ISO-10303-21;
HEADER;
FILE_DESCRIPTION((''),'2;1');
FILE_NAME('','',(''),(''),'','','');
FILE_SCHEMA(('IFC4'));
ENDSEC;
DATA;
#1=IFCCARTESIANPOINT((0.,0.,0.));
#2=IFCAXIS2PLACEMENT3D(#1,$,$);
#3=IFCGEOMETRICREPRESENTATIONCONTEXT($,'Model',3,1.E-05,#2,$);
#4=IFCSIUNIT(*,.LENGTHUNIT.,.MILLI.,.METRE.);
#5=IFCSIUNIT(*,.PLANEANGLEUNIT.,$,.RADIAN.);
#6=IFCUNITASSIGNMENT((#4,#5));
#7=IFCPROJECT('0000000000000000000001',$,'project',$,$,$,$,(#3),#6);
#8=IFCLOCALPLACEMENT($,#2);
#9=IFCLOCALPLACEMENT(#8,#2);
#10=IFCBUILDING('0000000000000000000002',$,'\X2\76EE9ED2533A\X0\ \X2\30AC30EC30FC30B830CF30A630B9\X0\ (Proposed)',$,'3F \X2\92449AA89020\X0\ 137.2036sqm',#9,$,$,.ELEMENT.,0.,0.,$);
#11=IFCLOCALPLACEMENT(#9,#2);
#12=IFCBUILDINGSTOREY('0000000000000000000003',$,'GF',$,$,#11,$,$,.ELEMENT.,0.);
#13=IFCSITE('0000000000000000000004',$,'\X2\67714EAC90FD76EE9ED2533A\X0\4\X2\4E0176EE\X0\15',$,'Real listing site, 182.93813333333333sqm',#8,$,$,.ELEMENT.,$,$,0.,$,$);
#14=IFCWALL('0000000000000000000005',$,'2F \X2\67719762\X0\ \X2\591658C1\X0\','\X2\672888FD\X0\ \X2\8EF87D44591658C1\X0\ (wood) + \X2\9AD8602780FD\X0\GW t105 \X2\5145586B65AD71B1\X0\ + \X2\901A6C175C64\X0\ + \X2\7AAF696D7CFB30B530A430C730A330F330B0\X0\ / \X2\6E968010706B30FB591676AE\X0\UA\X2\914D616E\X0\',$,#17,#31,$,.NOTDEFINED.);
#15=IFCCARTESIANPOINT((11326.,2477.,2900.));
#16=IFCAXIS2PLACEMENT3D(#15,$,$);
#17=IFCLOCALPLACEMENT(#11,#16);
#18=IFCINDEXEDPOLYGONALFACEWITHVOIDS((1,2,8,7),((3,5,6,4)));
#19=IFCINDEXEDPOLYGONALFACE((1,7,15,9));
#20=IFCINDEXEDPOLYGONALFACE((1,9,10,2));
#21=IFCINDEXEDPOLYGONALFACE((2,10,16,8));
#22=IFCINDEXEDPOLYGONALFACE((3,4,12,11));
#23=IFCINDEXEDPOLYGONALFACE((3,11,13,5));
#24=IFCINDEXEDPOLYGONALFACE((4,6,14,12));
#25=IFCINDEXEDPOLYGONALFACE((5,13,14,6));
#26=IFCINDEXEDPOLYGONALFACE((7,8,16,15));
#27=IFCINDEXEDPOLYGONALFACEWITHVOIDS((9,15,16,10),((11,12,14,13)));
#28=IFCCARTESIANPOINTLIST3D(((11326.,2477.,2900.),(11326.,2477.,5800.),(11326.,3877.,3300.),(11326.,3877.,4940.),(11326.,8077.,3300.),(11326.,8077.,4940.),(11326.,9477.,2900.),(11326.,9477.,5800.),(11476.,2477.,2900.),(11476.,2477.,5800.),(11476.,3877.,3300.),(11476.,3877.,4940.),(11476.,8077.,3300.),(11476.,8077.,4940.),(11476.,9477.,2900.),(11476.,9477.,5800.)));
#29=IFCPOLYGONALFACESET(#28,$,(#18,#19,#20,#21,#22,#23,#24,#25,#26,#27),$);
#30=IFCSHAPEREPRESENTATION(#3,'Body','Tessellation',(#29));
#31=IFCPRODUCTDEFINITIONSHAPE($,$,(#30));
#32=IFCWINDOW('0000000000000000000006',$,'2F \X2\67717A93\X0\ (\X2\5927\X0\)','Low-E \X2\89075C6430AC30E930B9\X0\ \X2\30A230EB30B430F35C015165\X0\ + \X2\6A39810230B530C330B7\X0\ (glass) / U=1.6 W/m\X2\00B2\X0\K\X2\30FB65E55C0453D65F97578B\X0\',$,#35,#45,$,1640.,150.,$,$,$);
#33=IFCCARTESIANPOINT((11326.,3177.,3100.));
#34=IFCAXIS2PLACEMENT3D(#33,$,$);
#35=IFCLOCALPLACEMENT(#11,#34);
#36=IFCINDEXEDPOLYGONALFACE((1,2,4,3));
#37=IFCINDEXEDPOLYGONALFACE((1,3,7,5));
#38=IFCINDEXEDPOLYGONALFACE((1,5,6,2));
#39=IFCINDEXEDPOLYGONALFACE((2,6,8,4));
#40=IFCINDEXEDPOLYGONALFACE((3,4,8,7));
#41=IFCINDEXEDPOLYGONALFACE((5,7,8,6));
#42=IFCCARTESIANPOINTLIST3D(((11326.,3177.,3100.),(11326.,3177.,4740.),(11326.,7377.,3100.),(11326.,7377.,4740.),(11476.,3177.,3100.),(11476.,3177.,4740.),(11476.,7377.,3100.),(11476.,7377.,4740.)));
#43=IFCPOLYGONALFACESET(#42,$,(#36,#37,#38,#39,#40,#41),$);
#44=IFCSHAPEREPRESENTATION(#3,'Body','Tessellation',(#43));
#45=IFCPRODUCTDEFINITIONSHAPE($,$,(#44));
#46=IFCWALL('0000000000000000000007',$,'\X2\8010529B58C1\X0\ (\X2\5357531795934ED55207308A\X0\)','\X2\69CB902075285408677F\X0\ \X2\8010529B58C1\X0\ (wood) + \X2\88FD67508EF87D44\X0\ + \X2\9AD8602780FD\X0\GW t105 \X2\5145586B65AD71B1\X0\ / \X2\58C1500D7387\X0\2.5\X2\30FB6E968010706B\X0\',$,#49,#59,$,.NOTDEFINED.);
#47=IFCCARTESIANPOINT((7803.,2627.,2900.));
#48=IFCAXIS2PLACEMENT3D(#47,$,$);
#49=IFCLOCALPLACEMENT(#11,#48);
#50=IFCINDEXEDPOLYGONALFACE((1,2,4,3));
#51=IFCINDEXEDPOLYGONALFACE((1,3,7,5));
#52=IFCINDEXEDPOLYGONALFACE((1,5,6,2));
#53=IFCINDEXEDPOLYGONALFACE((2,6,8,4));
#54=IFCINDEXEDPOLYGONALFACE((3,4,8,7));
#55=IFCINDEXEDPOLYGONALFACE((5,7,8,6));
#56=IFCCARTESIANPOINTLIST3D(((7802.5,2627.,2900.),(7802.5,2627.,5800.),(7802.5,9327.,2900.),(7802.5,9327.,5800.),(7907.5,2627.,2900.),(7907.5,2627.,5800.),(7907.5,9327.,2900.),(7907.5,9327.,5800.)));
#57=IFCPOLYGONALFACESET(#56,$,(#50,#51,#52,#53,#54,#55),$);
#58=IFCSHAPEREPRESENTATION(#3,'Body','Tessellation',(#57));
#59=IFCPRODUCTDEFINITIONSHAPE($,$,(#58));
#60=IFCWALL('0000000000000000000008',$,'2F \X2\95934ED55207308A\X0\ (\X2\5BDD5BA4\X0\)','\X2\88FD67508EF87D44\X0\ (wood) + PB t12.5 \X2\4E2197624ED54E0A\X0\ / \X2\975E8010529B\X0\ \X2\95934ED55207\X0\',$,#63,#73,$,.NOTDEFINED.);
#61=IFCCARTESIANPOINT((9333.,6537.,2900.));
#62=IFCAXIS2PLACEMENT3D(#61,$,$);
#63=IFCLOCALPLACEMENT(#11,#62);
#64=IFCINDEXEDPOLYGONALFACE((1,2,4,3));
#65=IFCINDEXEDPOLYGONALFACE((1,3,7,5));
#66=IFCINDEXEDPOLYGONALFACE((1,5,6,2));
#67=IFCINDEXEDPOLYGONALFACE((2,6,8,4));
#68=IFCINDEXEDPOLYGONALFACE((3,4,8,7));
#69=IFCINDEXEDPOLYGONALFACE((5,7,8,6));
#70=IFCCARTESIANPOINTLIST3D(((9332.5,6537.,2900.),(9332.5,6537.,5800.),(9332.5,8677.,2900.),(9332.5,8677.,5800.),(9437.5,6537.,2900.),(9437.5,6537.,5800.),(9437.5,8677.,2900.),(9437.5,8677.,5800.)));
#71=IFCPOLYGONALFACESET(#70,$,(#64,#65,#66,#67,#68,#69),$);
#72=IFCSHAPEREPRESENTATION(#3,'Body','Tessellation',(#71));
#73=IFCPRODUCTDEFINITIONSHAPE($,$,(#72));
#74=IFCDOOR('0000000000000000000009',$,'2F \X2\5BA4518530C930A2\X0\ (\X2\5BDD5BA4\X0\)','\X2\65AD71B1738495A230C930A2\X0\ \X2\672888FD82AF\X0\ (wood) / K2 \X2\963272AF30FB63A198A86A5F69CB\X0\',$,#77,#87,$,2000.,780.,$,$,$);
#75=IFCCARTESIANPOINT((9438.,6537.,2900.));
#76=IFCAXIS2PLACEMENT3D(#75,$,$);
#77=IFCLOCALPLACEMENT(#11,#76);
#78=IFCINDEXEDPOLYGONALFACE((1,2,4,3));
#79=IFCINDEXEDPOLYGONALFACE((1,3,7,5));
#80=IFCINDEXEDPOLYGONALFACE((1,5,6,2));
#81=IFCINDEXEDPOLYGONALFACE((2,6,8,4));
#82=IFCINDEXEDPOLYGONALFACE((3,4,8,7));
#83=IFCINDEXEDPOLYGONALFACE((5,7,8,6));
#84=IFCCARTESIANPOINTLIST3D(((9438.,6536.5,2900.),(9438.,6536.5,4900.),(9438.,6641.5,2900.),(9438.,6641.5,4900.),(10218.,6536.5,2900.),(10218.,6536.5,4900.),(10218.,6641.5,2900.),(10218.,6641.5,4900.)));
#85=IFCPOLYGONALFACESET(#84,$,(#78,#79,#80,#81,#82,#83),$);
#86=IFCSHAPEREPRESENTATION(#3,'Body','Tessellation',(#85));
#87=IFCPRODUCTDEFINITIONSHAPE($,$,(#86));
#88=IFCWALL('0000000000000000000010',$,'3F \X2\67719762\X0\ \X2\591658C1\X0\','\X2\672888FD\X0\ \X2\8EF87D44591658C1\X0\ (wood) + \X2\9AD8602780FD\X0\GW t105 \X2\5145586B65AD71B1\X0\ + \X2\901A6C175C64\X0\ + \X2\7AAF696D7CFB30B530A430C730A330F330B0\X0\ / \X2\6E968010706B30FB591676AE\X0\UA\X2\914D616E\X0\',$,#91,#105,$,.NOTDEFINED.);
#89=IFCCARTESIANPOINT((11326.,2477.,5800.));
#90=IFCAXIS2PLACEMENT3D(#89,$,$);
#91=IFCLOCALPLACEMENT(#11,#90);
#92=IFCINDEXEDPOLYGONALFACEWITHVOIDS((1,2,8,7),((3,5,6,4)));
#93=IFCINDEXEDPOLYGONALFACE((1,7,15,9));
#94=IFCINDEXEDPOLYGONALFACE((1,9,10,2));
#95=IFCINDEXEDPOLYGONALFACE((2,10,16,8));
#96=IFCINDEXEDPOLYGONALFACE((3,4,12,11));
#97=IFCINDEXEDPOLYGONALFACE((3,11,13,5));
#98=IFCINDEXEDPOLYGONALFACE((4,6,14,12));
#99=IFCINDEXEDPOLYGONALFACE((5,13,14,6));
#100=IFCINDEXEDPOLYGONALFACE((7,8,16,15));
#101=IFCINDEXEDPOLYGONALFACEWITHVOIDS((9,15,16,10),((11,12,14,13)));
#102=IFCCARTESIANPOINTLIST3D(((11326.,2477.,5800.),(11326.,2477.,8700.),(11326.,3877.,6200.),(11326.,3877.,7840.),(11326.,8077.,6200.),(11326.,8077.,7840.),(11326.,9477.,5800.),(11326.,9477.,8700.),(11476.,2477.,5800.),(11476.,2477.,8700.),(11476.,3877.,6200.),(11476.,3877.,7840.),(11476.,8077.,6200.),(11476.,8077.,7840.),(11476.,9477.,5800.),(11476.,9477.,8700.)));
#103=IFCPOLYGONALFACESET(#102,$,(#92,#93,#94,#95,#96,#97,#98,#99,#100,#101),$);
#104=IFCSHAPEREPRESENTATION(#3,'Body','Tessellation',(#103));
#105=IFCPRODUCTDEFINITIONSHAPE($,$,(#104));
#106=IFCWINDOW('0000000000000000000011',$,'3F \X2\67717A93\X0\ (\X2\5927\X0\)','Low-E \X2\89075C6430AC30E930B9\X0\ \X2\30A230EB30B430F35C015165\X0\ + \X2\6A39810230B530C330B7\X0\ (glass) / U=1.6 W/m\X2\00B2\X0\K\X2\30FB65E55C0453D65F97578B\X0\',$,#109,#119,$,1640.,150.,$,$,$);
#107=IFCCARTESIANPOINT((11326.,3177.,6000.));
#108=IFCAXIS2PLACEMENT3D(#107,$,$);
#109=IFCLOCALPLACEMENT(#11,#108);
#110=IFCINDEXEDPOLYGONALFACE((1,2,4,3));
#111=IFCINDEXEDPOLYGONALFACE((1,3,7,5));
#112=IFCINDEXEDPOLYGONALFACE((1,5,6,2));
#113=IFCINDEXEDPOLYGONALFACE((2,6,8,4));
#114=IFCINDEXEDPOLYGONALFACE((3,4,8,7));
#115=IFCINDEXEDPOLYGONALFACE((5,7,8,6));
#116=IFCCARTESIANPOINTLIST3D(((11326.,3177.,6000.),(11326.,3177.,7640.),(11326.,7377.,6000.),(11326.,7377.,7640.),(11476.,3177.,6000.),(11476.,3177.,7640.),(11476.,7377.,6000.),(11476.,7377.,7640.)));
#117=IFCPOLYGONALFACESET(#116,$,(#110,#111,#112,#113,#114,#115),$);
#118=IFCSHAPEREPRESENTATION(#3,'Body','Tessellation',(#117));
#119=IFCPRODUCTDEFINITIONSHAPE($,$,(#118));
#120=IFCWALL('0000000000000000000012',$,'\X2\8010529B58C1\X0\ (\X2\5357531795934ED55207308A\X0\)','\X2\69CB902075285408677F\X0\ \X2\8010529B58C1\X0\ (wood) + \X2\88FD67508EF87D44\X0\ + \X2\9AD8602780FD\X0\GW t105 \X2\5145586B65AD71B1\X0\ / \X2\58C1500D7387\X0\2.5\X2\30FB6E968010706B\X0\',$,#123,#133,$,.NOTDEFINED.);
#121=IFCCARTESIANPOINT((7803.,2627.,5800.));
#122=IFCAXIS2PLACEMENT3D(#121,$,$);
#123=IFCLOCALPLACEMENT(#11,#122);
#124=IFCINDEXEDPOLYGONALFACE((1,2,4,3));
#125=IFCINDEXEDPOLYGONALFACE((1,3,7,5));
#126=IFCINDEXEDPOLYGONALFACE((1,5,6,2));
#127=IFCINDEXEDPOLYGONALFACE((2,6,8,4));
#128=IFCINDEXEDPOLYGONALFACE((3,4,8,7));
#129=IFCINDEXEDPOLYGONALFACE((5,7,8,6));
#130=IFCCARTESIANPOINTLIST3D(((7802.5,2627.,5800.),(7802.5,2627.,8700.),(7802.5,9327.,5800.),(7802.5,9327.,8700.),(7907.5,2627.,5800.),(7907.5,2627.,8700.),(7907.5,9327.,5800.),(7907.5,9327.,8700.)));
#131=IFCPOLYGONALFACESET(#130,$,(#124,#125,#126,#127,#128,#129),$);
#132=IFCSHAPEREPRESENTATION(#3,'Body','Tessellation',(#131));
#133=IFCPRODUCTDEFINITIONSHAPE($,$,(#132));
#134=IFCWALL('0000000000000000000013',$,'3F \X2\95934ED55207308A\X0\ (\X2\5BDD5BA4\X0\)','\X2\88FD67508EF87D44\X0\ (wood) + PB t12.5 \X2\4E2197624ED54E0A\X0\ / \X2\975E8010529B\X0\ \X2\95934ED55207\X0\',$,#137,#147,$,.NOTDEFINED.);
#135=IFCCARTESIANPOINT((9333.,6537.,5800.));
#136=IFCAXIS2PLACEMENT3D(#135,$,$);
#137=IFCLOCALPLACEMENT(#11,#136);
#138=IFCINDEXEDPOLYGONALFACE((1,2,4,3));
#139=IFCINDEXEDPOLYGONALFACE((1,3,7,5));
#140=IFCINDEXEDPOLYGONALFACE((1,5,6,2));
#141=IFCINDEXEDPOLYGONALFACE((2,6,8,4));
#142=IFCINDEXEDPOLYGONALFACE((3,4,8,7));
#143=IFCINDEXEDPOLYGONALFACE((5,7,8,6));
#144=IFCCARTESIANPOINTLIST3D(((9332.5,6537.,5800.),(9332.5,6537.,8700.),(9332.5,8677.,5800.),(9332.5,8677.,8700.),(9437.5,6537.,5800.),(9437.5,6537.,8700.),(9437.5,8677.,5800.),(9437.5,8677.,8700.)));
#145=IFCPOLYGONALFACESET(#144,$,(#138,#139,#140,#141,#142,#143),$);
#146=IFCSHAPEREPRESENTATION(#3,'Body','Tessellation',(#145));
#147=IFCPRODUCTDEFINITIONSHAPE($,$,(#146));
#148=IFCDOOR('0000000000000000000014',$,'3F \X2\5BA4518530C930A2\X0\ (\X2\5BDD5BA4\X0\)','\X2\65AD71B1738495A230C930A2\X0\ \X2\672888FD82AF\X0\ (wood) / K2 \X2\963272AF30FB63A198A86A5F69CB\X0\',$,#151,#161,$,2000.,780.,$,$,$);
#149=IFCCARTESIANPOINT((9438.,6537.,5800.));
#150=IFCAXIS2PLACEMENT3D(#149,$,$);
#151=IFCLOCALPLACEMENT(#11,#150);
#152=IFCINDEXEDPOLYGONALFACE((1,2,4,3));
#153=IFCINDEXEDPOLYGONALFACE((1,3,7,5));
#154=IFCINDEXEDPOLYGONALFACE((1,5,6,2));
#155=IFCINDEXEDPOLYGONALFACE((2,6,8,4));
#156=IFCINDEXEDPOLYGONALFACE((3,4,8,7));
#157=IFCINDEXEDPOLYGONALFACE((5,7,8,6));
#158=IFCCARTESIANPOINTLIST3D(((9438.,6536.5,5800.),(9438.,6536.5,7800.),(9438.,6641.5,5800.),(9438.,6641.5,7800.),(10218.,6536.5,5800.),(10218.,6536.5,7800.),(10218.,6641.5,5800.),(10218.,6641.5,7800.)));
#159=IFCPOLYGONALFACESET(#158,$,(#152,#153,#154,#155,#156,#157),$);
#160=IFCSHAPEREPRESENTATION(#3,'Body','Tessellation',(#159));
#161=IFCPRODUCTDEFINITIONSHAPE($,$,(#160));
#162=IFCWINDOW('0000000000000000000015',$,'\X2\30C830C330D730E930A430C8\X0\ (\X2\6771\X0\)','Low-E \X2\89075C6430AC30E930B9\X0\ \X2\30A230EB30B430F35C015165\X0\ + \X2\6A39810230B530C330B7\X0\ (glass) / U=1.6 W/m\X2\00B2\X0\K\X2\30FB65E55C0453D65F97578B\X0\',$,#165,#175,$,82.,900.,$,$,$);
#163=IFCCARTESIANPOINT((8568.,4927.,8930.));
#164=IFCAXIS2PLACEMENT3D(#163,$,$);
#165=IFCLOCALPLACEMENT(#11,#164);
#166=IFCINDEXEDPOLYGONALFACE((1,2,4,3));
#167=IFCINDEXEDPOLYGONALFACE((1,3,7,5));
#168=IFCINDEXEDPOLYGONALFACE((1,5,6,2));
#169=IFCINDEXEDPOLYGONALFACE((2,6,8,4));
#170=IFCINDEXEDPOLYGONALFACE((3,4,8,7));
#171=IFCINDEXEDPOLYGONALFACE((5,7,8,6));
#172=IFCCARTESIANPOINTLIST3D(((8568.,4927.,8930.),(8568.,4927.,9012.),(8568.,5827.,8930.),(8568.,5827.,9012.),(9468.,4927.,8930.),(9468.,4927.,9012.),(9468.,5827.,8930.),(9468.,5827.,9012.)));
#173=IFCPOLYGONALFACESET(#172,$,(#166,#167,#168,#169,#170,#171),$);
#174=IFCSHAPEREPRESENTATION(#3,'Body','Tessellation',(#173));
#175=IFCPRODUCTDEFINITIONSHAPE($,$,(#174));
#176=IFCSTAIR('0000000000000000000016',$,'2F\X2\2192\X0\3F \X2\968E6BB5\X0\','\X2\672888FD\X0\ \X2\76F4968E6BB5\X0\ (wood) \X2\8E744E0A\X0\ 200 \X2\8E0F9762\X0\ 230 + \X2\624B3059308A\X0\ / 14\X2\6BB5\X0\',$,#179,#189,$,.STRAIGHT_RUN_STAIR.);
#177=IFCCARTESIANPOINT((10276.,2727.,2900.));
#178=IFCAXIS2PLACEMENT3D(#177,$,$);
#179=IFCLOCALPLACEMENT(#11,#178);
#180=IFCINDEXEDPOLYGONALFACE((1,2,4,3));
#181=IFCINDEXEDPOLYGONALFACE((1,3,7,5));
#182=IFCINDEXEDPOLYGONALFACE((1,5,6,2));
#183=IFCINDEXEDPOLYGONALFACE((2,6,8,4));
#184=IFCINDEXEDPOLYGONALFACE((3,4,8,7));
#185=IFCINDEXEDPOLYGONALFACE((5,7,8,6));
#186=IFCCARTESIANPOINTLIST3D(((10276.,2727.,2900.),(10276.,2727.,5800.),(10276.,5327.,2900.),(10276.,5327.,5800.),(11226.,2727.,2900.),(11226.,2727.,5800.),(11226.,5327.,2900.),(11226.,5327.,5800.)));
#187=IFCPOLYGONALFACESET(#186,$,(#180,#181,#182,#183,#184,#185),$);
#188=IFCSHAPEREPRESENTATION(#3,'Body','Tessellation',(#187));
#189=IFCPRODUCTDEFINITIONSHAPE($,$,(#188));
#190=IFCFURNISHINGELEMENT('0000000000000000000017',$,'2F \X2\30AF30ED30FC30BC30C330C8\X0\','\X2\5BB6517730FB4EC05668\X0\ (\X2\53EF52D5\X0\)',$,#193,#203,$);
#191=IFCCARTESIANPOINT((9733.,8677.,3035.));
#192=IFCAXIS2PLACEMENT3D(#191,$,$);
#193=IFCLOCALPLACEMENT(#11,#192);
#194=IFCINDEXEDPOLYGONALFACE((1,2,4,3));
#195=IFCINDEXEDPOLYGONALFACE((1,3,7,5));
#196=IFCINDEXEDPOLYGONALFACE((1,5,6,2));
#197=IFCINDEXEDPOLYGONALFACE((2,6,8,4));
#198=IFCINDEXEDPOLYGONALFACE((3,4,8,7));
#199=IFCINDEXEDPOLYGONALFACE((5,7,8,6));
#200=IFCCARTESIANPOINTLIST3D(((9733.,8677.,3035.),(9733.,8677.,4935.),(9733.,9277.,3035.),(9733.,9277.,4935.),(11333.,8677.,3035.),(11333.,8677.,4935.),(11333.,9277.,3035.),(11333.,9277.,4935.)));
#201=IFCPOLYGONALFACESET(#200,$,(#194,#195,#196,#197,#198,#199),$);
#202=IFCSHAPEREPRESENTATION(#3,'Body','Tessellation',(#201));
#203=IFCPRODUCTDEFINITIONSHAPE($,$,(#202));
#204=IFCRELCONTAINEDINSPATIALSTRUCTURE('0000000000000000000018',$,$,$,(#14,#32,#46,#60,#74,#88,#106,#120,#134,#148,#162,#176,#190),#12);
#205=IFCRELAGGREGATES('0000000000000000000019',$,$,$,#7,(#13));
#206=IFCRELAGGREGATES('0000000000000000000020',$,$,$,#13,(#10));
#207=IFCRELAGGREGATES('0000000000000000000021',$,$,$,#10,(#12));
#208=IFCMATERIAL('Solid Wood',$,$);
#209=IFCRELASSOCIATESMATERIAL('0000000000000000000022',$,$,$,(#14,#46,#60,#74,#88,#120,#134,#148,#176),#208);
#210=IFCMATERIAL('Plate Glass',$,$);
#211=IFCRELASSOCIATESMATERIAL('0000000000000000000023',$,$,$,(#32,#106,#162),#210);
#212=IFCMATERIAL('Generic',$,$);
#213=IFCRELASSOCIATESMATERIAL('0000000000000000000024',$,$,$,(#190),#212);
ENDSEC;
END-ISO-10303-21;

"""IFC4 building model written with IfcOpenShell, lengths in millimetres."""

from ifc_helpers import new_model, si_unit, frame, frame_2d, origin, place, context, project, spatial, rectangle, extrude, material, element, fill, save


model = new_model("IFC4")

# Units and contexts
model_context = context("Model", 3, precision=1e-05, world=origin())
ifc_project = project(units=[si_unit("LENGTHUNIT", "METRE", prefix="MILLI"), si_unit("PLANEANGLEUNIT", "RADIAN")], contexts=[model_context])

# Site, building, storey
site_placement = place(None, origin())
site = spatial("IfcSite", under=ifc_project, at=site_placement, Name="東京都目黒区4丁目15", ObjectType="Real listing site, 182.93813333333333sqm", CompositionType="ELEMENT", RefElevation=0.0)
building_placement = place(site_placement, origin())
building = spatial("IfcBuilding", under=site, at=building_placement, Name="目黒区 ガレージハウス (Proposed)", ObjectType="3F 鉄骨造 137.2036sqm", CompositionType="ELEMENT", ElevationOfRefHeight=0.0, ElevationOfTerrain=0.0)
storey_placement = place(building_placement, origin())
storey = spatial("IfcBuildingStorey", under=building, at=storey_placement, Name="GF", CompositionType="ELEMENT", Elevation=0.0)

# Wall, opening, window
ifc_material_1 = material(Name="Solid Wood")
wall_1_placement = place(storey_placement, frame((11326.0, 2477.0, 2900.0)))
wall_1 = element("IfcWall", 1, at=wall_1_placement, inside=storey, material=ifc_material_1, Name="2F 東面 外壁", Description="木製 軸組外壁 (wood) + 高性能GW t105 充填断熱 + 通気層 + 窯業系サイディング / 準耐火・外皮UA配慮", PredefinedType="NOTDEFINED", context=model_context, shape_type="SweptSolid", body=[
    extrude(rectangle(XDim=150.0, YDim=7000.0, at=frame_2d((75.0, 3500.0))), frame((11326.0, 2477.0, 2900.0)), (0.0, 0.0, 1.0), 2900.0),
])
opening_1_placement = place(storey_placement, frame((11326.0, 3177.0, 3100.0)))
opening_1 = element("IfcOpeningElement", 2, at=opening_1_placement, cuts=wall_1, PredefinedType="NOTDEFINED", context=model_context, shape_type="SweptSolid", body=[
    extrude(rectangle(XDim=150.0, YDim=4200.0, at=frame_2d((75.0, 2100.0))), frame((11326.0, 3177.0, 3100.0)), (0.0, 0.0, 1.0), 1640.0),
])
ifc_material_2 = material(Name="Plate Glass")
window_1_placement = place(storey_placement, frame((11326.0, 3177.0, 3100.0)))
window_1 = element("IfcWindow", 3, at=window_1_placement, inside=storey, material=ifc_material_2, Name="2F 東窓 (大)", Description="Low-E 複層ガラス アルゴン封入 + 樹脂サッシ (glass) / U=1.6 W/m²K・日射取得型", OverallHeight=1640.0, OverallWidth=150.0, context=model_context, shape_type="SweptSolid", body=[
    extrude(rectangle(XDim=150.0, YDim=4200.0, at=frame_2d((75.0, 2100.0))), frame((11326.0, 3177.0, 3100.0)), (0.0, 0.0, 1.0), 1640.0),
])
fill(opening_1, window_1)

# Walls
wall_2_placement = place(storey_placement, frame((7803.0, 2627.0, 2900.0)))
element("IfcWall", 4, at=wall_2_placement, inside=storey, material=ifc_material_1, Name="耐力壁 (南北間仕切り)", Description="構造用合板 耐力壁 (wood) + 製材軸組 + 高性能GW t105 充填断熱 / 壁倍率2.5・準耐火", PredefinedType="NOTDEFINED", context=model_context, shape_type="SweptSolid", body=[
    extrude(rectangle(XDim=105.0, YDim=6700.0, at=frame_2d((52.0, 3350.0))), frame((7803.0, 2627.0, 2900.0)), (0.0, 0.0, 1.0), 2900.0),
])
wall_3_placement = place(storey_placement, frame((9333.0, 6537.0, 2900.0)))
element("IfcWall", 5, at=wall_3_placement, inside=storey, material=ifc_material_1, Name="2F 間仕切り (寝室)", Description="製材軸組 (wood) + PB t12.5 両面仕上 / 非耐力 間仕切", PredefinedType="NOTDEFINED", context=model_context, shape_type="SweptSolid", body=[
    extrude(rectangle(XDim=105.0, YDim=2140.0, at=frame_2d((52.0, 1070.0))), frame((9333.0, 6537.0, 2900.0)), (0.0, 0.0, 1.0), 2900.0),
])

# Door
door_1_placement = place(storey_placement, frame((9438.0, 6537.0, 2900.0)))
element("IfcDoor", 6, at=door_1_placement, inside=storey, material=ifc_material_1, Name="2F 室内ドア (寝室)", Description="断熱玄関ドア 木製芯 (wood) / K2 防犯・採風機構", OverallHeight=2000.0, OverallWidth=780.0, context=model_context, shape_type="SweptSolid", body=[
    extrude(rectangle(XDim=780.0, YDim=105.0, at=frame_2d((390.0, 52.0))), frame((9438.0, 6537.0, 2900.0)), (0.0, 0.0, 1.0), 2000.0),
])

# Wall, opening, window
wall_4_placement = place(storey_placement, frame((11326.0, 2477.0, 5800.0)))
wall_4 = element("IfcWall", 7, at=wall_4_placement, inside=storey, material=ifc_material_1, Name="3F 東面 外壁", Description="木製 軸組外壁 (wood) + 高性能GW t105 充填断熱 + 通気層 + 窯業系サイディング / 準耐火・外皮UA配慮", PredefinedType="NOTDEFINED", context=model_context, shape_type="SweptSolid", body=[
    extrude(rectangle(XDim=150.0, YDim=7000.0, at=frame_2d((75.0, 3500.0))), frame((11326.0, 2477.0, 5800.0)), (0.0, 0.0, 1.0), 2900.0),
])
opening_2_placement = place(storey_placement, frame((11326.0, 3177.0, 6000.0)))
opening_2 = element("IfcOpeningElement", 8, at=opening_2_placement, cuts=wall_4, PredefinedType="NOTDEFINED", context=model_context, shape_type="SweptSolid", body=[
    extrude(rectangle(XDim=150.0, YDim=4200.0, at=frame_2d((75.0, 2100.0))), frame((11326.0, 3177.0, 6000.0)), (0.0, 0.0, 1.0), 1640.0),
])
window_2_placement = place(storey_placement, frame((11326.0, 3177.0, 6000.0)))
window_2 = element("IfcWindow", 9, at=window_2_placement, inside=storey, material=ifc_material_2, Name="3F 東窓 (大)", Description="Low-E 複層ガラス アルゴン封入 + 樹脂サッシ (glass) / U=1.6 W/m²K・日射取得型", OverallHeight=1640.0, OverallWidth=150.0, context=model_context, shape_type="SweptSolid", body=[
    extrude(rectangle(XDim=150.0, YDim=4200.0, at=frame_2d((75.0, 2100.0))), frame((11326.0, 3177.0, 6000.0)), (0.0, 0.0, 1.0), 1640.0),
])
fill(opening_2, window_2)

# Walls
wall_5_placement = place(storey_placement, frame((7803.0, 2627.0, 5800.0)))
element("IfcWall", 10, at=wall_5_placement, inside=storey, material=ifc_material_1, Name="耐力壁 (南北間仕切り)", Description="構造用合板 耐力壁 (wood) + 製材軸組 + 高性能GW t105 充填断熱 / 壁倍率2.5・準耐火", PredefinedType="NOTDEFINED", context=model_context, shape_type="SweptSolid", body=[
    extrude(rectangle(XDim=105.0, YDim=6700.0, at=frame_2d((52.0, 3350.0))), frame((7803.0, 2627.0, 5800.0)), (0.0, 0.0, 1.0), 2900.0),
])
wall_6_placement = place(storey_placement, frame((9333.0, 6537.0, 5800.0)))
element("IfcWall", 11, at=wall_6_placement, inside=storey, material=ifc_material_1, Name="3F 間仕切り (寝室)", Description="製材軸組 (wood) + PB t12.5 両面仕上 / 非耐力 間仕切", PredefinedType="NOTDEFINED", context=model_context, shape_type="SweptSolid", body=[
    extrude(rectangle(XDim=105.0, YDim=2140.0, at=frame_2d((52.0, 1070.0))), frame((9333.0, 6537.0, 5800.0)), (0.0, 0.0, 1.0), 2900.0),
])

# Door
door_2_placement = place(storey_placement, frame((9438.0, 6537.0, 5800.0)))
element("IfcDoor", 12, at=door_2_placement, inside=storey, material=ifc_material_1, Name="3F 室内ドア (寝室)", Description="断熱玄関ドア 木製芯 (wood) / K2 防犯・採風機構", OverallHeight=2000.0, OverallWidth=780.0, context=model_context, shape_type="SweptSolid", body=[
    extrude(rectangle(XDim=780.0, YDim=105.0, at=frame_2d((390.0, 52.0))), frame((9438.0, 6537.0, 5800.0)), (0.0, 0.0, 1.0), 2000.0),
])

# Window
window_3_placement = place(storey_placement, frame((8568.0, 4927.0, 8930.0)))
element("IfcWindow", 13, at=window_3_placement, inside=storey, material=ifc_material_2, Name="トップライト (東)", Description="Low-E 複層ガラス アルゴン封入 + 樹脂サッシ (glass) / U=1.6 W/m²K・日射取得型", OverallHeight=82.0, OverallWidth=900.0, context=model_context, shape_type="SweptSolid", body=[
    extrude(rectangle(XDim=900.0, YDim=900.0, at=frame_2d((450.0, 450.0))), frame((8568.0, 4927.0, 8930.0)), (0.0, 0.0, 1.0), 82.0),
])

# Stair
stair_placement = place(storey_placement, frame((10276.0, 2727.0, 2900.0)))
element("IfcStair", 14, at=stair_placement, inside=storey, material=ifc_material_1, Name="2F→3F 階段", Description="木製 直階段 (wood) 蹴上 200 踏面 230 + 手すり / 14段", PredefinedType="STRAIGHT_RUN_STAIR", context=model_context, shape_type="SweptSolid", body=[
    extrude(rectangle(XDim=950.0, YDim=2600.0, at=frame_2d((475.0, 1300.0))), frame((10276.0, 2727.0, 2900.0)), (0.0, 0.0, 1.0), 2900.0),
])

# Furnishing element
ifc_material_3 = material(Name="Generic")
furnishing_1_placement = place(storey_placement, frame((9733.0, 8677.0, 3035.0)))
element("IfcFurnishingElement", 15, at=furnishing_1_placement, inside=storey, material=ifc_material_3, Name="2F クローゼット", Description="家具・什器 (可動)", context=model_context, shape_type="SweptSolid", body=[
    extrude(rectangle(XDim=1600.0, YDim=600.0, at=frame_2d((800.0, 300.0))), frame((9733.0, 8677.0, 3035.0)), (0.0, 0.0, 1.0), 1900.0),
])

save(model, "model.ifc")
